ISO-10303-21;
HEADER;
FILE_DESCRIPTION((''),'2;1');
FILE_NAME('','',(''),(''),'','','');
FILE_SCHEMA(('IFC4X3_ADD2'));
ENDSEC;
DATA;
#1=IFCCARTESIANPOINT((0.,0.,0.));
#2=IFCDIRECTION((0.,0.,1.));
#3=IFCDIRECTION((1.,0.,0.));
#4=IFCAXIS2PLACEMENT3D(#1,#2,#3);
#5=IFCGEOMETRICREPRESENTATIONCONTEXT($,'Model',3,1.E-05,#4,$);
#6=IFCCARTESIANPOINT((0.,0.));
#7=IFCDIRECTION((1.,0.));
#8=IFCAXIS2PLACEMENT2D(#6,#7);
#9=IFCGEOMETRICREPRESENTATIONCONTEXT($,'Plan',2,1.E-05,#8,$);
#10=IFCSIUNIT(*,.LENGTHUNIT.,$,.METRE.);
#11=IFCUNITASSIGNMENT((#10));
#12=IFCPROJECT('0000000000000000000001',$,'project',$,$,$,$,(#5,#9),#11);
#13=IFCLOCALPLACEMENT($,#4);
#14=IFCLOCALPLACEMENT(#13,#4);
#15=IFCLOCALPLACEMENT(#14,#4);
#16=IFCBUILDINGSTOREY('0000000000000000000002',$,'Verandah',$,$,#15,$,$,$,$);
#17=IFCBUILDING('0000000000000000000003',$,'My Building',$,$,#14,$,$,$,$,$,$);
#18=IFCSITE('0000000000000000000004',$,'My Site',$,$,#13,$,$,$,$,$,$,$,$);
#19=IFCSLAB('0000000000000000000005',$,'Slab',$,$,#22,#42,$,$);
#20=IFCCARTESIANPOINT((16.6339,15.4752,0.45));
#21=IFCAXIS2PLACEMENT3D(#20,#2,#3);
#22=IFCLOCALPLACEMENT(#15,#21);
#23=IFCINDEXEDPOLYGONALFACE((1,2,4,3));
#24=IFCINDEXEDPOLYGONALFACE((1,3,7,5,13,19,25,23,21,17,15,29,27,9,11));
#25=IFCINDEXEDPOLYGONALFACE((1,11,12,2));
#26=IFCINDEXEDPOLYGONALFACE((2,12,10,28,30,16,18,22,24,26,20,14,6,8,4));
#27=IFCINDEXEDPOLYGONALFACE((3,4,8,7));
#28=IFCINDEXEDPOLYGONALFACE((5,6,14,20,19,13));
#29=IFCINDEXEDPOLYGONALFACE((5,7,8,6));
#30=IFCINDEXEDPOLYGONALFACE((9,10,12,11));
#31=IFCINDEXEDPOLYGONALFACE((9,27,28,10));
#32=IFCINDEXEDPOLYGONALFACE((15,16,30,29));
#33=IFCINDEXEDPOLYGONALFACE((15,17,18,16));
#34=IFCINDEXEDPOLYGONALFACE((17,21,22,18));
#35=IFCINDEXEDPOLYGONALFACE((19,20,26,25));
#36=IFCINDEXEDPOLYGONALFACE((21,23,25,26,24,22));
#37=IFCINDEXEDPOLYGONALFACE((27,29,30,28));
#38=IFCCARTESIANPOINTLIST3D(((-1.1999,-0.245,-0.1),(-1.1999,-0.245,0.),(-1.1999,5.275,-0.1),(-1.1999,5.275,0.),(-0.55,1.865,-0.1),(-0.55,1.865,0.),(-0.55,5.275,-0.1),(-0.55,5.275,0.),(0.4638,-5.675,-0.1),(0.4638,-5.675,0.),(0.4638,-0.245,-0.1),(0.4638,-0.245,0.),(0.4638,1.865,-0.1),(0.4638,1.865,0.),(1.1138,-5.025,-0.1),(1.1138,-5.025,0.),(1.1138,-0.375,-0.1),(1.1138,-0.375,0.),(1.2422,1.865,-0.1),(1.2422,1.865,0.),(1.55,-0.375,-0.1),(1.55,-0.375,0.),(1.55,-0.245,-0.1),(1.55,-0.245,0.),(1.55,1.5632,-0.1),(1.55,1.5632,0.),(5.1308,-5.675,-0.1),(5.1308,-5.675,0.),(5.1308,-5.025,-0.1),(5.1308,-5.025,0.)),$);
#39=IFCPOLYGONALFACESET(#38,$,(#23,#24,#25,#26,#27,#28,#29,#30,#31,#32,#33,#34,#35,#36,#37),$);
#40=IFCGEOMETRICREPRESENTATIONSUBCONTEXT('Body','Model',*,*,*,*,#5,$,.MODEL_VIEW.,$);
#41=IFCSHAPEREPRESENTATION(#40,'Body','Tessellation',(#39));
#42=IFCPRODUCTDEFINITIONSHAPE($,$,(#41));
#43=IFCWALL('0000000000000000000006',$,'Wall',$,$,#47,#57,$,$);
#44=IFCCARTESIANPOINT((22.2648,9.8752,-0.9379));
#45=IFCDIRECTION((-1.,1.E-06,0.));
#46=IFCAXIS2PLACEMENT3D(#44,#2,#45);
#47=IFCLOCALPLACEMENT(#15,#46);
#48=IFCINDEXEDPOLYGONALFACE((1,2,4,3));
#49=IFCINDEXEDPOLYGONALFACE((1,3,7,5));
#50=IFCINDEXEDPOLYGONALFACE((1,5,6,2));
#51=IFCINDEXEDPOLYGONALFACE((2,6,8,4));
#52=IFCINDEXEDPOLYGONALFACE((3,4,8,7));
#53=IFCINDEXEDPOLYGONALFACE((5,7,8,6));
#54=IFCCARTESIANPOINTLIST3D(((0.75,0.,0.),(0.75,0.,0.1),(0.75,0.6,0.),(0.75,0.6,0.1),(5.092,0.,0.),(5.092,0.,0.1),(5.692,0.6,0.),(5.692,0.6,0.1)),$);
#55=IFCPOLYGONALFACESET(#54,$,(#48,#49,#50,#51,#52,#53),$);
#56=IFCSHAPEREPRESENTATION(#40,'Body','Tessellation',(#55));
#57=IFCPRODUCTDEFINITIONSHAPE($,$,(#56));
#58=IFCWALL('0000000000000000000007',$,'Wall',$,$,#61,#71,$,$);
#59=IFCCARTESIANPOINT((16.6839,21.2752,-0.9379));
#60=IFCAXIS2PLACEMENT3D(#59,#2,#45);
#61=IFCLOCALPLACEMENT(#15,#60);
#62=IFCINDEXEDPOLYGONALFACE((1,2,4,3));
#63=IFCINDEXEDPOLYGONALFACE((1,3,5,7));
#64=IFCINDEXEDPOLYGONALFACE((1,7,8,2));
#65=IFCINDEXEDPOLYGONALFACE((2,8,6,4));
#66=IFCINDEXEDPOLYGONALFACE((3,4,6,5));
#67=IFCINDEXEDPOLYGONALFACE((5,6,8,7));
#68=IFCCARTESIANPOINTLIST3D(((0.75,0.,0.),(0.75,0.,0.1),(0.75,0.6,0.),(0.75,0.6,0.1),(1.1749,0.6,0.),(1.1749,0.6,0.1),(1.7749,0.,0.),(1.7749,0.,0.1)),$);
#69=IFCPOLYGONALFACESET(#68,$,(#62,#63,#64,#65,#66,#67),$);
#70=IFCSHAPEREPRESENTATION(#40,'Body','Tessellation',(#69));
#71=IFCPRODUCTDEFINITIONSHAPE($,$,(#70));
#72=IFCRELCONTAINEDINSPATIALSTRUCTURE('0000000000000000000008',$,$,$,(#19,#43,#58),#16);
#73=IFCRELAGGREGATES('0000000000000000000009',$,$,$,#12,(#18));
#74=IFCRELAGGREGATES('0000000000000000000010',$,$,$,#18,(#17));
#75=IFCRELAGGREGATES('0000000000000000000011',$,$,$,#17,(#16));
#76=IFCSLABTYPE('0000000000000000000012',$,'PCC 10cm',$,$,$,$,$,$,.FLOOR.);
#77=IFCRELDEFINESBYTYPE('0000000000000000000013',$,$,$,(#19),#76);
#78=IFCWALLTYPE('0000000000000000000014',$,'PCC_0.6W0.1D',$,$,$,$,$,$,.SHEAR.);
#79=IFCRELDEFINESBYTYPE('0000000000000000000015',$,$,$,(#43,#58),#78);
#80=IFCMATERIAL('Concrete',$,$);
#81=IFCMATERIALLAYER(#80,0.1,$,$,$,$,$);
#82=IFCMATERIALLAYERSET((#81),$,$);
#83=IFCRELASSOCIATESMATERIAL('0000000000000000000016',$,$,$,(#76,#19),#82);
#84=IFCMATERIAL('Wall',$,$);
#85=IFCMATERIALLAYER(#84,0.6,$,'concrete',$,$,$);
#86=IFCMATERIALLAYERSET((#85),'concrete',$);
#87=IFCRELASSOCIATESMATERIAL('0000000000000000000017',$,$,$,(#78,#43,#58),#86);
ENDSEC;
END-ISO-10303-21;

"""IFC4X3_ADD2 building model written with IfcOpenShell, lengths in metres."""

from ifc_helpers import new_model, si_unit, frame, origin_with_axes, origin_2d_with_axis, place, context, subcontext, project, spatial, line, indexed_curve, outline, extrude, material, layer, layer_set, layer_usage, type_object, element, save


model = new_model("IFC4X3_ADD2")

# Units and contexts
model_context = context("Model", 3, precision=1e-05, world=origin_with_axes())
plan_context = context("Plan", 2, precision=1e-05, world=origin_2d_with_axis())
body_context = subcontext(model_context, "Body", "Model", "MODEL_VIEW")
ifc_project = project(units=[si_unit("LENGTHUNIT", "METRE")], contexts=[model_context, plan_context])

# Site, building, storey
site_placement = place(None, origin_with_axes())
site = spatial("IfcSite", under=ifc_project, at=site_placement, Name="My Site")
building_placement = place(site_placement, origin_with_axes())
building = spatial("IfcBuilding", under=site, at=building_placement, Name="My Building")
storey_placement = place(building_placement, origin_with_axes())
storey = spatial("IfcBuildingStorey", under=building, at=storey_placement, Name="Verandah")

# Slab
ifc_material_1 = material(Name="Concrete")
ifc_layer_1 = layer(ifc_material_1, 0.1)
ifc_layer_set_1 = layer_set([ifc_layer_1])
ifc_layer_usage_1 = layer_usage(ifc_layer_set_1, "AXIS3", "POSITIVE", -0.1)
slab_type = type_object("IfcSlabType", Name="PCC 10cm", PredefinedType="FLOOR", material=ifc_layer_set_1)
slab_placement = place(storey_placement, frame((16.6339, 15.4752, 0.45), z_axis=(0.0, 0.0, 1.0), x_axis=(1.0, 0.0, 0.0)))
element("IfcSlab", 1, at=slab_placement, inside=storey, type_object=slab_type, material=ifc_layer_usage_1, Name="Slab", context=body_context, shape_type="SweptSolid", body=[
    extrude(outline(indexed_curve([(1.55, -0.375), (1.1138, -0.375), (1.1138, -5.025), (5.1308, -5.025), (5.1308, -5.675), (0.4638, -5.675), (0.4638, -0.245), (-1.1999, -0.245), (-1.1999, 5.275), (-0.55, 5.275), (-0.55, 1.865), (0.4638, 1.865), (1.2422, 1.865), (1.55, 1.5632), (1.55, -0.245), (1.55, -0.375)])), frame((0.0, 0.0, -0.1), z_axis=(0.0, 0.0, 1.0), x_axis=(1.0, 0.0, 0.0)), (0.0, 0.0, 1.0), 0.1),
])

# Walls
ifc_material_2 = material(Name="Wall")
ifc_layer_2 = layer(ifc_material_2, 0.6, Name="concrete")
ifc_layer_set_2 = layer_set([ifc_layer_2], Name="concrete")
wall_type_1 = type_object("IfcWallType", Name="PCC_0.6W0.1D", PredefinedType="SHEAR", material=ifc_layer_set_2)
ifc_layer_usage_2 = layer_usage(ifc_layer_set_2, "AXIS2", "POSITIVE", 0.0)
wall_1_placement = place(storey_placement, frame((22.2648, 9.8752, -0.9379), z_axis=(0.0, 0.0, 1.0), x_axis=(-1.0, 0.000001, 0.0)))
element("IfcWall", 2, at=wall_1_placement, inside=storey, type_object=wall_type_1, material=ifc_layer_usage_2, Name="Wall", context=body_context, shape_type="SweptSolid", body=[
    extrude(outline(indexed_curve([(0.75, 0.0), (0.75, 0.6), (5.692, 0.6), (5.092, 0.0)], segments=[line(1, 2, 3, 4, 1)])), origin_with_axes(), (0.0, 0.0, 1.0), 0.1),
])
ifc_layer_usage_3 = layer_usage(ifc_layer_set_2, "AXIS2", "POSITIVE", 0.0)
wall_2_placement = place(storey_placement, frame((16.6839, 21.2752, -0.9379), z_axis=(0.0, 0.0, 1.0), x_axis=(-1.0, 0.000001, 0.0)))
element("IfcWall", 3, at=wall_2_placement, inside=storey, type_object=wall_type_1, material=ifc_layer_usage_3, Name="Wall", context=body_context, shape_type="SweptSolid", body=[
    extrude(outline(indexed_curve([(0.75, 0.0), (0.75, 0.6), (1.1749, 0.6), (1.7749, 0.0)], segments=[line(1, 2, 3, 4, 1)])), origin_with_axes(), (0.0, 0.0, 1.0), 0.1),
])

save(model, "model.ifc")
